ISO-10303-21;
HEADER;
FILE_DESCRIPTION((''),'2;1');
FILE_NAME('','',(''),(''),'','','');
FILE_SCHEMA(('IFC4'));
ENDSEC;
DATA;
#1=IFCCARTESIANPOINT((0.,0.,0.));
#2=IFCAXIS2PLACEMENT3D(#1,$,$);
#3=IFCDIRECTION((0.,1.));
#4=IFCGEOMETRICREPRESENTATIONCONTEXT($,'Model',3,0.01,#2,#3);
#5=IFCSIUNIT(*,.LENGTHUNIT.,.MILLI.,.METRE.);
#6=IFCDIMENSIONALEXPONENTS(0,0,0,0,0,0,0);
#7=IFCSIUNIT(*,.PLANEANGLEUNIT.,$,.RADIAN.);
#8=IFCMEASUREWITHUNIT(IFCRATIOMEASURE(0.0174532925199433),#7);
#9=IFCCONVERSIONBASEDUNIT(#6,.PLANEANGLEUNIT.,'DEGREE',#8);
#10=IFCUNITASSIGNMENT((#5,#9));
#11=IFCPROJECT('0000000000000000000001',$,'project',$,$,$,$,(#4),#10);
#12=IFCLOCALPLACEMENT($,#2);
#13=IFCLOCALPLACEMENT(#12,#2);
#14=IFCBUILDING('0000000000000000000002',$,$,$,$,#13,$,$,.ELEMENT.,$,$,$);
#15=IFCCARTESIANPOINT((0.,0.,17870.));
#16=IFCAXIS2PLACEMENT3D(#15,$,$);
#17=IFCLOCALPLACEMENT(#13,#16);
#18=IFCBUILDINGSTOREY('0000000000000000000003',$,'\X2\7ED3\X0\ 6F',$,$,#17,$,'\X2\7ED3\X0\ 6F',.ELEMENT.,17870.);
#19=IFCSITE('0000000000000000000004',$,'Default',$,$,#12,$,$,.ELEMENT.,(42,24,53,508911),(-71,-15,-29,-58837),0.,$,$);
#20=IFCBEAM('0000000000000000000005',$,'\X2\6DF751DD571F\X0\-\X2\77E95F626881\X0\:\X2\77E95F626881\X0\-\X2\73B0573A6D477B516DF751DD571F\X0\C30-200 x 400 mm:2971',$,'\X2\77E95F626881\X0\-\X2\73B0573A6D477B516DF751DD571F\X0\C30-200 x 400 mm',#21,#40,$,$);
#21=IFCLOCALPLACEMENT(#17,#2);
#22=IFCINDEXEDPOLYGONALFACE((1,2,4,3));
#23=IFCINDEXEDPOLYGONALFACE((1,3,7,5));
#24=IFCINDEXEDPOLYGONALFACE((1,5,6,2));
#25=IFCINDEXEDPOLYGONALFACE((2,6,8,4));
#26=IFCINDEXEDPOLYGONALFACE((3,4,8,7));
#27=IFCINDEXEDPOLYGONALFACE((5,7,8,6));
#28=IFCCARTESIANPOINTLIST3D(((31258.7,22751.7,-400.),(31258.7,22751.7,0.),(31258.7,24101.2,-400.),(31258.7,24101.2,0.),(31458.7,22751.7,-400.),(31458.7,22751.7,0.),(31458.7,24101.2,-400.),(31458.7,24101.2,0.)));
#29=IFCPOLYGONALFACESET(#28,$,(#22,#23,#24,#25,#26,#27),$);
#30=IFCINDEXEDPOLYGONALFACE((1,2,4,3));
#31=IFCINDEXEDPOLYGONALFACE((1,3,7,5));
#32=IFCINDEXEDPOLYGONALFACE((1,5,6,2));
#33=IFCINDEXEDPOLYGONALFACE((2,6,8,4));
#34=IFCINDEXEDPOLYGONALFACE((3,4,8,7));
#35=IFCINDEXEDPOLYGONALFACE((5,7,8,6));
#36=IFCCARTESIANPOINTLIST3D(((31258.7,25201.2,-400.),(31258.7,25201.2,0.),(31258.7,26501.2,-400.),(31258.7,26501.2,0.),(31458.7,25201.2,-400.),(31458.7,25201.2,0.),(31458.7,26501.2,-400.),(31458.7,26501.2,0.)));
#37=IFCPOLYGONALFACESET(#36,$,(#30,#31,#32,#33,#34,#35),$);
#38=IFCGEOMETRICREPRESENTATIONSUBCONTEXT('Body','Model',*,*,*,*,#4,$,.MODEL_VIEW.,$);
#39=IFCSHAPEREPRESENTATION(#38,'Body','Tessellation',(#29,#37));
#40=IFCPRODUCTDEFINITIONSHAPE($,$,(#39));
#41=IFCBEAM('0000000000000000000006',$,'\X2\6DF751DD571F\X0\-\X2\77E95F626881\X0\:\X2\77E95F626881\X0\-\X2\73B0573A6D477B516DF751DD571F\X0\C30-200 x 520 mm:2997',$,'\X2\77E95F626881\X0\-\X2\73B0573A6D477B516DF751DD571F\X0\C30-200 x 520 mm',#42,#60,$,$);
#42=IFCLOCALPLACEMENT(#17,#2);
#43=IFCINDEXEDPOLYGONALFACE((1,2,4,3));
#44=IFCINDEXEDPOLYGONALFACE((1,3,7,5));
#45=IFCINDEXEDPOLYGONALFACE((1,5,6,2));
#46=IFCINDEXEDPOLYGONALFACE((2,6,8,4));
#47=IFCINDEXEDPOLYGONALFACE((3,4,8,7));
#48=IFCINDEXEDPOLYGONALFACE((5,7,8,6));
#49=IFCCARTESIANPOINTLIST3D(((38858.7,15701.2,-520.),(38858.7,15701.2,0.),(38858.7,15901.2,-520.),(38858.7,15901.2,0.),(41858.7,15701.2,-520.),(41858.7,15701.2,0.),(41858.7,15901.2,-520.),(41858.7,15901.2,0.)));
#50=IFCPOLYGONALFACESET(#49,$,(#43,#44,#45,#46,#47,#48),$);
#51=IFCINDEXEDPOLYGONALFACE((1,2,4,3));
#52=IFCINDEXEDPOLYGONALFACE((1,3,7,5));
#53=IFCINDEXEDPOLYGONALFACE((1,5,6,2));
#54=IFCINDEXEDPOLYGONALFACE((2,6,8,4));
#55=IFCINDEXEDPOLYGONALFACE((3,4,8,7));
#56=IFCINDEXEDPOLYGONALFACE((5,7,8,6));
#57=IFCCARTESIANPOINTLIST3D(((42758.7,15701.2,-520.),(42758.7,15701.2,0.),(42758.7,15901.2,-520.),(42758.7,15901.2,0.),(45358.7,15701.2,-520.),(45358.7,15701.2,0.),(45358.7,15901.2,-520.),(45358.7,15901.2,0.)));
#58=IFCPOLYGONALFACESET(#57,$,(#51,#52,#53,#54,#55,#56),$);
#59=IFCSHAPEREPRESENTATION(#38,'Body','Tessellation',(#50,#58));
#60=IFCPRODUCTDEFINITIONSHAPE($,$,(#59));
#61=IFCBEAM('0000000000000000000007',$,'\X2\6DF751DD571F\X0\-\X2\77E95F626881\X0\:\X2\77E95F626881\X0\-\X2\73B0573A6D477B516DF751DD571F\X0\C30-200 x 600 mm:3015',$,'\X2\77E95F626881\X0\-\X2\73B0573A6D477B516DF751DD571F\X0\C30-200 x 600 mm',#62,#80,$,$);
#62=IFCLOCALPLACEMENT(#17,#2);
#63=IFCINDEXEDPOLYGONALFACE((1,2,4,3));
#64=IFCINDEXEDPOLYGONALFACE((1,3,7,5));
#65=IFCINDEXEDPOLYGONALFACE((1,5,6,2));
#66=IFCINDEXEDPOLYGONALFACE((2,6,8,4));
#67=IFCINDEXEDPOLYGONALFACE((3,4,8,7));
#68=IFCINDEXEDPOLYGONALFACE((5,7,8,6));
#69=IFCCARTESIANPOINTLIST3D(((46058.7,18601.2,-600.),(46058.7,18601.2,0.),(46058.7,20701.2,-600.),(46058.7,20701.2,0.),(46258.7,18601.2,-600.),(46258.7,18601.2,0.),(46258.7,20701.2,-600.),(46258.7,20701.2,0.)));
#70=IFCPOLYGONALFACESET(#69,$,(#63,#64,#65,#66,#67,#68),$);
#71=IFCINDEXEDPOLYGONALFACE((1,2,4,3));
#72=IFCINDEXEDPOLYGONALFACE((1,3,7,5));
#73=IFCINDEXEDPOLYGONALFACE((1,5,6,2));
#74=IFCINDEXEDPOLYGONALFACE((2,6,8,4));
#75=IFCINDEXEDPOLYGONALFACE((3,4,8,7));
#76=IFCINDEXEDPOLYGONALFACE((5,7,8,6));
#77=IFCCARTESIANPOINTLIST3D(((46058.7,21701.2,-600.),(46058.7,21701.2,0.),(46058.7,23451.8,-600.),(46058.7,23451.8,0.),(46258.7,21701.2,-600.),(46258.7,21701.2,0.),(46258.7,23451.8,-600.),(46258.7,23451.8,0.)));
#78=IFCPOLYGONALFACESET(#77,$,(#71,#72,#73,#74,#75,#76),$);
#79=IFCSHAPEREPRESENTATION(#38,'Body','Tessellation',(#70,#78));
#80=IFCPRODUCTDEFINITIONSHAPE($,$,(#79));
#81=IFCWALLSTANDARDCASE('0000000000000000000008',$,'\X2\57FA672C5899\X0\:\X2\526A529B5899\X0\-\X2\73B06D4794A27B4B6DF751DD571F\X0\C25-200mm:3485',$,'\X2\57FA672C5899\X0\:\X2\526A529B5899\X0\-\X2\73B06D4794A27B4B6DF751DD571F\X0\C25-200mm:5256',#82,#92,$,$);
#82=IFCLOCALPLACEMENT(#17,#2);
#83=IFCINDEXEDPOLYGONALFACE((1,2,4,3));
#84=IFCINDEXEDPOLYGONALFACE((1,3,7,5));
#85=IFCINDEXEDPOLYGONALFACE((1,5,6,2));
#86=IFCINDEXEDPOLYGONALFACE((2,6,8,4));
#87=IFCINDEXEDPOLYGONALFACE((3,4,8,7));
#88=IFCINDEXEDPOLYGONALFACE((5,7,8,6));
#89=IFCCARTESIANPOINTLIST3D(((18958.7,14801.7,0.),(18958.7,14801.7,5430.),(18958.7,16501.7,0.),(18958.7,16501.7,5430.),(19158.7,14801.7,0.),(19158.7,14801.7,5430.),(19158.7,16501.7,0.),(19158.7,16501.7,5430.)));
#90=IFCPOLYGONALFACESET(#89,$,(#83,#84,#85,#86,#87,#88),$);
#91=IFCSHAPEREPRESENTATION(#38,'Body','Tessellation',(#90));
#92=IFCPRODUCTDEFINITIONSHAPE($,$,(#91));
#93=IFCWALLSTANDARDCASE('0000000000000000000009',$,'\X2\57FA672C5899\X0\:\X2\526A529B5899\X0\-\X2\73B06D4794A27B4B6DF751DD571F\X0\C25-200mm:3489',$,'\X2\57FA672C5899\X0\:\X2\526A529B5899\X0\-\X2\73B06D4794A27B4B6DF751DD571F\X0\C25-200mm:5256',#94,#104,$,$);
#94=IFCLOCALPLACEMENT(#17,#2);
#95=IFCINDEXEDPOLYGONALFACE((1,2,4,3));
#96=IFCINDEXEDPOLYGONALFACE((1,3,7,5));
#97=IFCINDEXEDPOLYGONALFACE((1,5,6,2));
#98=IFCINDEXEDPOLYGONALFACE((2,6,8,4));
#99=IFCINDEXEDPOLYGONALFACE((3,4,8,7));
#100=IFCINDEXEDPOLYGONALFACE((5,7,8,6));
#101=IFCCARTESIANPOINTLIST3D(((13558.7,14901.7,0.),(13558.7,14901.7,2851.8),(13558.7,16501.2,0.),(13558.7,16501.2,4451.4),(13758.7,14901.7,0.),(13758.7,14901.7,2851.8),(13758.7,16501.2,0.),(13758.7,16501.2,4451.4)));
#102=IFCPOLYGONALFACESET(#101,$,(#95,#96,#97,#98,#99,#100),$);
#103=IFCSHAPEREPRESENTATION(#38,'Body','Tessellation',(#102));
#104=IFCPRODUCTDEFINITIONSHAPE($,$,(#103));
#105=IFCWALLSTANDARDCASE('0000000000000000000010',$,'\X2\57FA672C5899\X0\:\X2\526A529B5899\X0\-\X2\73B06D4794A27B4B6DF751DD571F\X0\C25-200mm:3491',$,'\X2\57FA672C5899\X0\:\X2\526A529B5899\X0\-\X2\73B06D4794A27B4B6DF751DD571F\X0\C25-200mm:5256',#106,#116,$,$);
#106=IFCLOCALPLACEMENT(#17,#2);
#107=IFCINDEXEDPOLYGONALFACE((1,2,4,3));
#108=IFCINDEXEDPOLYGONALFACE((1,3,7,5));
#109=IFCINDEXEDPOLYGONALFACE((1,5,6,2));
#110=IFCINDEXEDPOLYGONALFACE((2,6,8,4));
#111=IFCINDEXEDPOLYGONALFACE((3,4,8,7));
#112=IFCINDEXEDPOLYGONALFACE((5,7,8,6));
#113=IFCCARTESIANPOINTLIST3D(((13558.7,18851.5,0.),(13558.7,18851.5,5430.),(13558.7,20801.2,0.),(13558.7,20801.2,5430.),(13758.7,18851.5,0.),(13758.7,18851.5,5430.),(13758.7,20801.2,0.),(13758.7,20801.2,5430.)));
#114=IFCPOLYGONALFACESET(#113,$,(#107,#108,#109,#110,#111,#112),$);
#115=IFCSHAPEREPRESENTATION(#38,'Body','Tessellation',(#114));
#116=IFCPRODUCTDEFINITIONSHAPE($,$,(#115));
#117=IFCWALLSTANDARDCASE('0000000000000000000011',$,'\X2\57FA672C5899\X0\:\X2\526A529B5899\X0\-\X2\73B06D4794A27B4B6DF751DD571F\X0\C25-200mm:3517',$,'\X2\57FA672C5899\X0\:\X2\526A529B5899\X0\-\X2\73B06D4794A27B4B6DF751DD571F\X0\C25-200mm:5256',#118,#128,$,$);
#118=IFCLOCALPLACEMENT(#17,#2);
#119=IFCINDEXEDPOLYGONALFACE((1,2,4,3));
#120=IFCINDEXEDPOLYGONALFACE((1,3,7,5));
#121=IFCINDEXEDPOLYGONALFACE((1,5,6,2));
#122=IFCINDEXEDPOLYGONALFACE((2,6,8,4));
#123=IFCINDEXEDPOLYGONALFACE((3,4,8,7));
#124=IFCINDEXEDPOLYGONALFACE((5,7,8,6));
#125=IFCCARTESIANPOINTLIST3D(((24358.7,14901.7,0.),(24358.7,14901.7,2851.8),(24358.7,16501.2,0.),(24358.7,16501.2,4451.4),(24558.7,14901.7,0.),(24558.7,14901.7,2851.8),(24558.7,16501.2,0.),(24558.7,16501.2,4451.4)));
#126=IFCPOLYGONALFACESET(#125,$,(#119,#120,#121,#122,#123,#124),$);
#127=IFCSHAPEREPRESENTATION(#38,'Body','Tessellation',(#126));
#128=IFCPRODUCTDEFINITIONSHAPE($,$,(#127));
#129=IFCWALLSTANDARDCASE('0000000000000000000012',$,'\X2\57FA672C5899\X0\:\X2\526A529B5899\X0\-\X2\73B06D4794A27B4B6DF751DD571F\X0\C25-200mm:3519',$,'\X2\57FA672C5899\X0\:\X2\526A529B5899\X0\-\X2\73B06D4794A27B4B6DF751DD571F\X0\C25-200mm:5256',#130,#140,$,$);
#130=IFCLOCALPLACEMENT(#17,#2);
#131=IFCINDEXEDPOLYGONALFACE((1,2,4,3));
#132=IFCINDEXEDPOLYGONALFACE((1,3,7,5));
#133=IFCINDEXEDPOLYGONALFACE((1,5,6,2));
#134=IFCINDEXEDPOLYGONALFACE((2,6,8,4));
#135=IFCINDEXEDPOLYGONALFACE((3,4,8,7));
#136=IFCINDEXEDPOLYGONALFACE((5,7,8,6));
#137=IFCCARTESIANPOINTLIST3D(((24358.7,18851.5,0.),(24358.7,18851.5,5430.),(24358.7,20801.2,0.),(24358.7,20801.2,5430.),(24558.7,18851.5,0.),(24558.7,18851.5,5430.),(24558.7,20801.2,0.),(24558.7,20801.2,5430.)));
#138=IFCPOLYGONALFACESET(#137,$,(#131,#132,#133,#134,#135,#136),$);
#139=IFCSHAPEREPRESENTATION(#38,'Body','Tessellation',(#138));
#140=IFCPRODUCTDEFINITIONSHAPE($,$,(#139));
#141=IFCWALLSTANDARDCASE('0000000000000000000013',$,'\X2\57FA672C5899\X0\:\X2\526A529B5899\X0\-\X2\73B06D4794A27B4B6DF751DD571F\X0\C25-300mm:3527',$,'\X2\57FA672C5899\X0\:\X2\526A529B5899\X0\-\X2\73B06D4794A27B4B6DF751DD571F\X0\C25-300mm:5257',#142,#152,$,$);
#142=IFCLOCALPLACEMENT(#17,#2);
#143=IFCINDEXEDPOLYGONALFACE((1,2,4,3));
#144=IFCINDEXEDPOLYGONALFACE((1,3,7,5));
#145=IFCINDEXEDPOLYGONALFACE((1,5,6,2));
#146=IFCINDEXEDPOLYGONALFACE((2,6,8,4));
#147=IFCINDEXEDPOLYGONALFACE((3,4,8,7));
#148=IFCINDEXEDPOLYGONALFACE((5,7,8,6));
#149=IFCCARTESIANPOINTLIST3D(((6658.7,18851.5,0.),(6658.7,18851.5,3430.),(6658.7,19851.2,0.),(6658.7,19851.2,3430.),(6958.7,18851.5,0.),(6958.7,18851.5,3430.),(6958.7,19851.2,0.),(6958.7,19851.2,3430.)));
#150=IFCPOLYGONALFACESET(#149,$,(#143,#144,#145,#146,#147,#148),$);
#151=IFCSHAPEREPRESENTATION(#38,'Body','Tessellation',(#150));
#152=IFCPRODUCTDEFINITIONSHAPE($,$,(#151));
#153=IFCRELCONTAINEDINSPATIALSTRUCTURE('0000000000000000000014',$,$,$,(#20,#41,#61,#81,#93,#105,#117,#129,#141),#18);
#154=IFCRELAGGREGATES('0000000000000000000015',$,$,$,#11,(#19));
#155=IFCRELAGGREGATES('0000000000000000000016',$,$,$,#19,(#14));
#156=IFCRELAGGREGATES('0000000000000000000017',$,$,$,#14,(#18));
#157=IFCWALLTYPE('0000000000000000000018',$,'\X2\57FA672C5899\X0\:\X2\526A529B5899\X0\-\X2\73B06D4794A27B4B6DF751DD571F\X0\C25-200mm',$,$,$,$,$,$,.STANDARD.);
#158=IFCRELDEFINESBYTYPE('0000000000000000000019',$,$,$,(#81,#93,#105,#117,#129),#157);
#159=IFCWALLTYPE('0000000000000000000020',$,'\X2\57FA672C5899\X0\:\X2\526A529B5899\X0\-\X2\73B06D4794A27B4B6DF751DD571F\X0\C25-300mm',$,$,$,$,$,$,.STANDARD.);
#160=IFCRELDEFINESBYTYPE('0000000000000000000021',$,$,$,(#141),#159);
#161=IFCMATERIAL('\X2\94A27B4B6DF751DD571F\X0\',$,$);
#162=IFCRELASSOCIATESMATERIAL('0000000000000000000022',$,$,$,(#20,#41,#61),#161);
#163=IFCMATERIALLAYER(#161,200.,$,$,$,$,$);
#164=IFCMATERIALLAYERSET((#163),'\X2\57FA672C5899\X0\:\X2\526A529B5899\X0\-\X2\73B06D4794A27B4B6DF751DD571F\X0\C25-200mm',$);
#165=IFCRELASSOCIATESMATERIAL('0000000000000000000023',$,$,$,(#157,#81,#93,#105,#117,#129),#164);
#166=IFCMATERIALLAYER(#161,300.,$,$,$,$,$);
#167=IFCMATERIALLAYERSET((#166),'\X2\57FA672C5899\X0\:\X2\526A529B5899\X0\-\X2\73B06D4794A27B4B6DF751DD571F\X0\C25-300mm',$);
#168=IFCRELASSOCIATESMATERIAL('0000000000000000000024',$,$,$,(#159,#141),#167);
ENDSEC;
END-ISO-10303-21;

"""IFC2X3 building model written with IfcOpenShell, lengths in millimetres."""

from ifc_helpers import new_model, entity, si_unit, converted_unit, direction, frame, frame_2d, origin, origin_2d_with_axis, place, context, subcontext, project, spatial, rectangle, extrude, clip, halfspace, source, transform, mapped, material, layer, layer_set, layer_usage, type_object, element, save


model = new_model("IFC2X3")

# Units and contexts
model_context = context("Model", 3, precision=0.01, world=origin(), true_north=direction((0.0, 1.0)))
body_context = subcontext(model_context, "Body", "Model", "MODEL_VIEW")
ifc_project = project(units=[si_unit("LENGTHUNIT", "METRE", prefix="MILLI"), converted_unit("PLANEANGLEUNIT", "DEGREE", entity("IfcRatioMeasure", 0.0174532925199433), si_unit("PLANEANGLEUNIT", "RADIAN"), dimensions=[0, 0, 0, 0, 0, 0, 0])], contexts=[model_context])

# Site, building, storey
site_placement = place(None, origin())
site = spatial("IfcSite", under=ifc_project, at=site_placement, Name="Default", CompositionType="ELEMENT", RefLatitude=(42, 24, 53, 508911), RefLongitude=(-71, -15, -29, -58837), RefElevation=0.0)
building_placement = place(site_placement, origin())
building = spatial("IfcBuilding", under=site, at=building_placement, CompositionType="ELEMENT")
storey_placement = place(building_placement, frame((0.0, 0.0, 17870.0)))
storey = spatial("IfcBuildingStorey", under=building, at=storey_placement, Name="结 6F", LongName="结 6F", CompositionType="ELEMENT", Elevation=17870.0)

# Beams
ifc_material = material(Name="钢筋混凝土")
shared_shape_1 = source(origin(), body_context, "Body", "SweptSolid", [
    extrude(rectangle(XDim=1349.5, YDim=200.0, at=origin_2d_with_axis()), frame((31358.7, 23426.5, 17470.0), z_axis=(0.0, 0.0, 1.0), x_axis=(0.0, 1.0, 0.0)), (0.0, 0.0, 1.0), 400.0),
    extrude(rectangle(XDim=200.0, YDim=1300.0, at=origin_2d_with_axis()), frame((31358.7, 25851.2, 17470.0), z_axis=(0.0, 0.0, 1.0), x_axis=(-1.0, 0.0, 0.0)), (0.0, 0.0, 1.0), 400.0),
])
beam_1_placement = place(storey_placement, frame((0.0, 0.0, -17870.0)))
element("IfcBeam", 1, at=beam_1_placement, inside=storey, material=ifc_material, Name="混凝土-矩形梁:矩形梁-现场浇筑混凝土C30-200 x 400 mm:2971", ObjectType="矩形梁-现场浇筑混凝土C30-200 x 400 mm", context=body_context, shape_type="MappedRepresentation", body=[
    mapped(shared_shape_1, transform((0.0, 0.0, 0.0), scale=1.0)),
])
shared_shape_2 = source(origin(), body_context, "Body", "SweptSolid", [
    extrude(rectangle(XDim=3000.0, YDim=200.0, at=origin_2d_with_axis()), frame((40358.7, 15801.2, 17350.0)), (0.0, 0.0, 1.0), 520.0),
    extrude(rectangle(XDim=2600.0, YDim=200.0, at=frame_2d((0.0, 0.0), x_axis=(1.0, 0.0))), frame((44058.7, 15801.2, 17350.0)), (0.0, 0.0, 1.0), 520.0),
])
beam_2_placement = place(storey_placement, frame((0.0, 0.0, -17870.0)))
element("IfcBeam", 2, at=beam_2_placement, inside=storey, material=ifc_material, Name="混凝土-矩形梁:矩形梁-现场浇筑混凝土C30-200 x 520 mm:2997", ObjectType="矩形梁-现场浇筑混凝土C30-200 x 520 mm", context=body_context, shape_type="MappedRepresentation", body=[
    mapped(shared_shape_2, transform((0.0, 0.0, 0.0), scale=1.0)),
])
shared_shape_3 = source(origin(), body_context, "Body", "SweptSolid", [
    extrude(rectangle(XDim=2100.0, YDim=200.0, at=frame_2d((0.0, 0.0), x_axis=(1.0, 0.0))), frame((46158.7, 19651.2, 17270.0), z_axis=(0.0, 0.0, 1.0), x_axis=(0.0, 1.0, 0.0)), (0.0, 0.0, 1.0), 600.0),
    extrude(rectangle(XDim=1750.6, YDim=200.0, at=frame_2d((0.0, 0.0), x_axis=(1.0, 0.0))), frame((46158.7, 22576.5, 17270.0), z_axis=(0.0, 0.0, 1.0), x_axis=(0.0, 1.0, 0.0)), (0.0, 0.0, 1.0), 600.0),
])
beam_3_placement = place(storey_placement, frame((0.0, 0.0, -17870.0)))
element("IfcBeam", 3, at=beam_3_placement, inside=storey, material=ifc_material, Name="混凝土-矩形梁:矩形梁-现场浇筑混凝土C30-200 x 600 mm:3015", ObjectType="矩形梁-现场浇筑混凝土C30-200 x 600 mm", context=body_context, shape_type="MappedRepresentation", body=[
    mapped(shared_shape_3, transform((0.0, 0.0, 0.0), scale=1.0)),
])

# Walls
ifc_layer_1 = layer(ifc_material, 200.0)
ifc_layer_set_1 = layer_set([ifc_layer_1], Name="基本墙:剪力墙-现浇钢筋混凝土C25-200mm")
ifc_layer_usage_1 = layer_usage(ifc_layer_set_1, "AXIS2", "NEGATIVE", 100.0)
wall_type_1 = type_object("IfcWallType", Name="基本墙:剪力墙-现浇钢筋混凝土C25-200mm", PredefinedType="STANDARD", material=ifc_layer_set_1)
wall_1_placement = place(storey_placement, frame((19058.7, 14801.7, 0.0), z_axis=(0.0, 0.0, 1.0), x_axis=(0.0, 1.0, 0.0)))
element("IfcWallStandardCase", 4, at=wall_1_placement, inside=storey, type_object=wall_type_1, material=ifc_layer_usage_1, Name="基本墙:剪力墙-现浇钢筋混凝土C25-200mm:3485", ObjectType="基本墙:剪力墙-现浇钢筋混凝土C25-200mm:5256", context=body_context, shape_type="SweptSolid", body=[
    extrude(rectangle(XDim=1700.0, YDim=200.0, at=frame_2d((850.0, 0.0), x_axis=(-1.0, 0.0))), origin(), (0.0, 0.0, 1.0), 5430.0),
])
ifc_layer_usage_2 = layer_usage(ifc_layer_set_1, "AXIS2", "NEGATIVE", 100.0)
wall_2_placement = place(storey_placement, frame((13658.7, 14901.7, 0.0), z_axis=(0.0, 0.0, 1.0), x_axis=(0.0, 1.0, 0.0)))
element("IfcWallStandardCase", 5, at=wall_2_placement, inside=storey, type_object=wall_type_1, material=ifc_layer_usage_2, Name="基本墙:剪力墙-现浇钢筋混凝土C25-200mm:3489", ObjectType="基本墙:剪力墙-现浇钢筋混凝土C25-200mm:5256", context=body_context, shape_type="Clipping", body=[
    clip(extrude(rectangle(XDim=1599.5, YDim=200.0, at=frame_2d((799.8, 0.0), x_axis=(-1.0, 0.0))), origin(), (0.0, 0.0, 1.0), 4451.4), halfspace(frame((0.0, -100.0, 2851.8), z_axis=(-0.707107, 0.0, 0.707107), x_axis=(0.0, 1.0, 0.0)), False)),
])
ifc_layer_usage_3 = layer_usage(ifc_layer_set_1, "AXIS2", "NEGATIVE", 100.0)
wall_3_placement = place(storey_placement, frame((13658.7, 18851.5, 0.0), z_axis=(0.0, 0.0, 1.0), x_axis=(0.0, 1.0, 0.0)))
element("IfcWallStandardCase", 6, at=wall_3_placement, inside=storey, type_object=wall_type_1, material=ifc_layer_usage_3, Name="基本墙:剪力墙-现浇钢筋混凝土C25-200mm:3491", ObjectType="基本墙:剪力墙-现浇钢筋混凝土C25-200mm:5256", context=body_context, shape_type="SweptSolid", body=[
    extrude(rectangle(XDim=1949.8, YDim=200.0, at=frame_2d((974.9, 0.0), x_axis=(-1.0, 0.0))), origin(), (0.0, 0.0, 1.0), 5430.0),
])
ifc_layer_usage_4 = layer_usage(ifc_layer_set_1, "AXIS2", "POSITIVE", -100.0)
wall_4_placement = place(storey_placement, frame((24458.7, 14901.7, 0.0), z_axis=(0.0, 0.0, 1.0), x_axis=(0.0, 1.0, 0.0)))
element("IfcWallStandardCase", 7, at=wall_4_placement, inside=storey, type_object=wall_type_1, material=ifc_layer_usage_4, Name="基本墙:剪力墙-现浇钢筋混凝土C25-200mm:3517", ObjectType="基本墙:剪力墙-现浇钢筋混凝土C25-200mm:5256", context=body_context, shape_type="Clipping", body=[
    clip(extrude(rectangle(XDim=1599.5, YDim=200.0, at=frame_2d((799.8, 0.0), x_axis=(-1.0, 0.0))), origin(), (0.0, 0.0, 1.0), 4451.4), halfspace(frame((0.0, -100.0, 2851.8), z_axis=(-0.707107, 0.0, 0.707107), x_axis=(0.0, 1.0, 0.0)), False)),
])
ifc_layer_usage_5 = layer_usage(ifc_layer_set_1, "AXIS2", "POSITIVE", -100.0)
wall_5_placement = place(storey_placement, frame((24458.7, 18851.5, 0.0), z_axis=(0.0, 0.0, 1.0), x_axis=(0.0, 1.0, 0.0)))
element("IfcWallStandardCase", 8, at=wall_5_placement, inside=storey, type_object=wall_type_1, material=ifc_layer_usage_5, Name="基本墙:剪力墙-现浇钢筋混凝土C25-200mm:3519", ObjectType="基本墙:剪力墙-现浇钢筋混凝土C25-200mm:5256", context=body_context, shape_type="SweptSolid", body=[
    extrude(rectangle(XDim=1949.8, YDim=200.0, at=frame_2d((974.9, 0.0), x_axis=(-1.0, 0.0))), origin(), (0.0, 0.0, 1.0), 5430.0),
])
ifc_layer_2 = layer(ifc_material, 300.0)
ifc_layer_set_2 = layer_set([ifc_layer_2], Name="基本墙:剪力墙-现浇钢筋混凝土C25-300mm")
ifc_layer_usage_6 = layer_usage(ifc_layer_set_2, "AXIS2", "NEGATIVE", 150.0)
wall_type_2 = type_object("IfcWallType", Name="基本墙:剪力墙-现浇钢筋混凝土C25-300mm", PredefinedType="STANDARD", material=ifc_layer_set_2)
wall_6_placement = place(storey_placement, frame((6808.7, 18851.5, 0.0), z_axis=(0.0, 0.0, 1.0), x_axis=(0.0, 1.0, 0.0)))
element("IfcWallStandardCase", 9, at=wall_6_placement, inside=storey, type_object=wall_type_2, material=ifc_layer_usage_6, Name="基本墙:剪力墙-现浇钢筋混凝土C25-300mm:3527", ObjectType="基本墙:剪力墙-现浇钢筋混凝土C25-300mm:5257", context=body_context, shape_type="SweptSolid", body=[
    extrude(rectangle(XDim=999.8, YDim=300.0, at=frame_2d((499.9, 0.0), x_axis=(-1.0, 0.0))), origin(), (0.0, 0.0, 1.0), 3430.0),
])

save(model, "model.ifc")
